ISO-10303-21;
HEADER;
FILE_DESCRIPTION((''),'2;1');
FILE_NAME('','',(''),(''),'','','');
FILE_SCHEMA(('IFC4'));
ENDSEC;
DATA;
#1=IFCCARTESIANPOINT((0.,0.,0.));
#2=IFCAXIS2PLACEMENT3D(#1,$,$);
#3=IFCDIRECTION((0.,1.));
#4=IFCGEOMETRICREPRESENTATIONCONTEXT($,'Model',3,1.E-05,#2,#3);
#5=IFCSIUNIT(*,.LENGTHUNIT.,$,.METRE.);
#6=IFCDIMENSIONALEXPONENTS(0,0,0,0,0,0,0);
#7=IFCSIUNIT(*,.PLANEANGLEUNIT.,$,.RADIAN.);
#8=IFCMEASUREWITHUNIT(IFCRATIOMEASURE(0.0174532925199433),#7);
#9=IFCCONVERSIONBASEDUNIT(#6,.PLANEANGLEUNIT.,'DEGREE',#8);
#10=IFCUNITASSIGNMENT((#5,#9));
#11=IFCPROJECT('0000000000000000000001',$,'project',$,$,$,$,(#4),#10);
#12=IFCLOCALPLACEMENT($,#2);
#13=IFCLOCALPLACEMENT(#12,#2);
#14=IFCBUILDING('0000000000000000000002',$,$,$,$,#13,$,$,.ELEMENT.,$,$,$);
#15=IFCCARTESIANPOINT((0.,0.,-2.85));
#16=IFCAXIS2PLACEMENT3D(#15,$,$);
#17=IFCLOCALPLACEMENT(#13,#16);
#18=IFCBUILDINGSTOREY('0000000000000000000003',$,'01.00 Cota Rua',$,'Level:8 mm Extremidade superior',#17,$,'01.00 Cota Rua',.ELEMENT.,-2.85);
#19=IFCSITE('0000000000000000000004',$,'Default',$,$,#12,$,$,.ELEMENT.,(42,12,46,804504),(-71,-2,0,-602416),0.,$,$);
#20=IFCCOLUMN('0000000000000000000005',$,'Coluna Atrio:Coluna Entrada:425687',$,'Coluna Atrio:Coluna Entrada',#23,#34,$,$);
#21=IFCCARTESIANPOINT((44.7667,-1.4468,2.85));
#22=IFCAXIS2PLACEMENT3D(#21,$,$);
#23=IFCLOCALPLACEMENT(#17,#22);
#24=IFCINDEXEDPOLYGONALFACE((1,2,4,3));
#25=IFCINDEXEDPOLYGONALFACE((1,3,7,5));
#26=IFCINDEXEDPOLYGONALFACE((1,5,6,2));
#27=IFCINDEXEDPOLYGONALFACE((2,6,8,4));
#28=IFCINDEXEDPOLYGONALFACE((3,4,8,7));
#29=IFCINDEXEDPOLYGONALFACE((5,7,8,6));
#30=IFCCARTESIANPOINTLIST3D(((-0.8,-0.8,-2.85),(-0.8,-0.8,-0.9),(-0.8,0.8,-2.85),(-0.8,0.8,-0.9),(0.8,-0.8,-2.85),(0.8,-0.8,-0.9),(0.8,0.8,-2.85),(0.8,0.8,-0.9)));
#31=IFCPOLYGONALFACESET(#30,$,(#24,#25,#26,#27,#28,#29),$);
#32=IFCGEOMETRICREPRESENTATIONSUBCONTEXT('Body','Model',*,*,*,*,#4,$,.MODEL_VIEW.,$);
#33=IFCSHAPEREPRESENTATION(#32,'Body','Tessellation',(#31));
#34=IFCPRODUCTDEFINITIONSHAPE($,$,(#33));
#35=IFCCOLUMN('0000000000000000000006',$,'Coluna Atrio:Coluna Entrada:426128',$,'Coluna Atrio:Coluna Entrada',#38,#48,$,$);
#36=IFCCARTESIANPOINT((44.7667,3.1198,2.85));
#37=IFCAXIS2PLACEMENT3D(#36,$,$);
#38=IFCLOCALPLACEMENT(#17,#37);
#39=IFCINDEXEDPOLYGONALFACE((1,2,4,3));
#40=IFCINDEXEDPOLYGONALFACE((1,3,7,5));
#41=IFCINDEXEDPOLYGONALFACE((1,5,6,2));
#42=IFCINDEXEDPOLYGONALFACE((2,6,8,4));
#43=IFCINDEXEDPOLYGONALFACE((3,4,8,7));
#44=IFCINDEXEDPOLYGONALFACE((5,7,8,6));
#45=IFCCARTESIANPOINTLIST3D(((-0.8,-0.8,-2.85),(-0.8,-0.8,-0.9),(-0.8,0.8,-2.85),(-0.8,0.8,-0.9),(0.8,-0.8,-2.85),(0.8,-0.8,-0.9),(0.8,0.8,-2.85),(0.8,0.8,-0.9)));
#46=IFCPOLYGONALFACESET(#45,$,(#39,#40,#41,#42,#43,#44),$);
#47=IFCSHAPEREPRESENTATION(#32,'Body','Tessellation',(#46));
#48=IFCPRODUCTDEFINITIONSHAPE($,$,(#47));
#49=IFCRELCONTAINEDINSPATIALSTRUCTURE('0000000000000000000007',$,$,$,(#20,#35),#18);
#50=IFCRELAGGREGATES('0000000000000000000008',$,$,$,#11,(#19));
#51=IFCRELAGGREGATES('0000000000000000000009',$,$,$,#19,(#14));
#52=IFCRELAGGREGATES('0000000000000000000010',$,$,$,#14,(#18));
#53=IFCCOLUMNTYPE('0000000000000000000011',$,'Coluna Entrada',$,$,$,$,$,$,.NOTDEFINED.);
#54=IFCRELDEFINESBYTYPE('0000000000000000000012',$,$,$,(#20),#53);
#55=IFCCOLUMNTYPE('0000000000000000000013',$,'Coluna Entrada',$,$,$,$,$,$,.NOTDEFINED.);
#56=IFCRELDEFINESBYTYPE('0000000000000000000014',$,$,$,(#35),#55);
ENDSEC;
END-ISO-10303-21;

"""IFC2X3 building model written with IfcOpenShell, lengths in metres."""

from ifc_helpers import new_model, entity, si_unit, converted_unit, direction, frame, origin, origin_2d_with_axis, place, context, subcontext, project, spatial, rectangle, extrude, source, transform, mapped, type_object, type_shapes, element, save


model = new_model("IFC2X3")

# Units and contexts
model_context = context("Model", 3, precision=1e-05, world=origin(), true_north=direction((0.0, 1.0)))
body_context = subcontext(model_context, "Body", "Model", "MODEL_VIEW")
ifc_project = project(units=[si_unit("LENGTHUNIT", "METRE"), converted_unit("PLANEANGLEUNIT", "DEGREE", entity("IfcRatioMeasure", 0.0174532925199433), si_unit("PLANEANGLEUNIT", "RADIAN"), dimensions=[0, 0, 0, 0, 0, 0, 0])], contexts=[model_context])

# Site, building, storey
site_placement = place(None, origin())
site = spatial("IfcSite", under=ifc_project, at=site_placement, Name="Default", CompositionType="ELEMENT", RefLatitude=(42, 12, 46, 804504), RefLongitude=(-71, -2, 0, -602416), RefElevation=0.0)
building_placement = place(site_placement, origin())
building = spatial("IfcBuilding", under=site, at=building_placement, CompositionType="ELEMENT")
storey_placement = place(building_placement, frame((0.0, 0.0, -2.85)))
storey = spatial("IfcBuildingStorey", under=building, at=storey_placement, Name="01.00 Cota Rua", ObjectType="Level:8 mm Extremidade superior", LongName="01.00 Cota Rua", CompositionType="ELEMENT", Elevation=-2.85)

# Columns
column_type_1 = type_object("IfcColumnType", Name="Coluna Entrada", PredefinedType="NOTDEFINED")
shared_shape_1 = source(origin(), body_context, "Body", "SweptSolid", [
    extrude(rectangle(XDim=1.6, YDim=1.6, at=origin_2d_with_axis()), frame((0.0, 0.0, -2.85), z_axis=(0.0, 0.0, 1.0), x_axis=(0.0, -1.0, 0.0)), (0.0, 0.0, 1.0), 1.95),
])
type_shapes(column_type_1, [shared_shape_1])
column_1_placement = place(storey_placement, frame((44.7667, -1.4468, 2.85)))
element("IfcColumn", 1, at=column_1_placement, inside=storey, type_object=column_type_1, Name="Coluna Atrio:Coluna Entrada:425687", ObjectType="Coluna Atrio:Coluna Entrada", context=body_context, shape_type="MappedRepresentation", body=[
    mapped(shared_shape_1, transform((0.0, 0.0, 0.0), scale=1.0)),
])
column_type_2 = type_object("IfcColumnType", Name="Coluna Entrada", PredefinedType="NOTDEFINED")
shared_shape_2 = source(origin(), body_context, "Body", "SweptSolid", [
    extrude(rectangle(XDim=1.6, YDim=1.6, at=origin_2d_with_axis()), frame((0.0, 0.0, -2.85), z_axis=(0.0, 0.0, 1.0), x_axis=(0.0, -1.0, 0.0)), (0.0, 0.0, 1.0), 1.95),
])
type_shapes(column_type_2, [shared_shape_2])
column_2_placement = place(storey_placement, frame((44.7667, 3.1198, 2.85)))
element("IfcColumn", 2, at=column_2_placement, inside=storey, type_object=column_type_2, Name="Coluna Atrio:Coluna Entrada:426128", ObjectType="Coluna Atrio:Coluna Entrada", context=body_context, shape_type="MappedRepresentation", body=[
    mapped(shared_shape_2, transform((0.0, 0.0, 0.0), scale=1.0)),
])

save(model, "model.ifc")
